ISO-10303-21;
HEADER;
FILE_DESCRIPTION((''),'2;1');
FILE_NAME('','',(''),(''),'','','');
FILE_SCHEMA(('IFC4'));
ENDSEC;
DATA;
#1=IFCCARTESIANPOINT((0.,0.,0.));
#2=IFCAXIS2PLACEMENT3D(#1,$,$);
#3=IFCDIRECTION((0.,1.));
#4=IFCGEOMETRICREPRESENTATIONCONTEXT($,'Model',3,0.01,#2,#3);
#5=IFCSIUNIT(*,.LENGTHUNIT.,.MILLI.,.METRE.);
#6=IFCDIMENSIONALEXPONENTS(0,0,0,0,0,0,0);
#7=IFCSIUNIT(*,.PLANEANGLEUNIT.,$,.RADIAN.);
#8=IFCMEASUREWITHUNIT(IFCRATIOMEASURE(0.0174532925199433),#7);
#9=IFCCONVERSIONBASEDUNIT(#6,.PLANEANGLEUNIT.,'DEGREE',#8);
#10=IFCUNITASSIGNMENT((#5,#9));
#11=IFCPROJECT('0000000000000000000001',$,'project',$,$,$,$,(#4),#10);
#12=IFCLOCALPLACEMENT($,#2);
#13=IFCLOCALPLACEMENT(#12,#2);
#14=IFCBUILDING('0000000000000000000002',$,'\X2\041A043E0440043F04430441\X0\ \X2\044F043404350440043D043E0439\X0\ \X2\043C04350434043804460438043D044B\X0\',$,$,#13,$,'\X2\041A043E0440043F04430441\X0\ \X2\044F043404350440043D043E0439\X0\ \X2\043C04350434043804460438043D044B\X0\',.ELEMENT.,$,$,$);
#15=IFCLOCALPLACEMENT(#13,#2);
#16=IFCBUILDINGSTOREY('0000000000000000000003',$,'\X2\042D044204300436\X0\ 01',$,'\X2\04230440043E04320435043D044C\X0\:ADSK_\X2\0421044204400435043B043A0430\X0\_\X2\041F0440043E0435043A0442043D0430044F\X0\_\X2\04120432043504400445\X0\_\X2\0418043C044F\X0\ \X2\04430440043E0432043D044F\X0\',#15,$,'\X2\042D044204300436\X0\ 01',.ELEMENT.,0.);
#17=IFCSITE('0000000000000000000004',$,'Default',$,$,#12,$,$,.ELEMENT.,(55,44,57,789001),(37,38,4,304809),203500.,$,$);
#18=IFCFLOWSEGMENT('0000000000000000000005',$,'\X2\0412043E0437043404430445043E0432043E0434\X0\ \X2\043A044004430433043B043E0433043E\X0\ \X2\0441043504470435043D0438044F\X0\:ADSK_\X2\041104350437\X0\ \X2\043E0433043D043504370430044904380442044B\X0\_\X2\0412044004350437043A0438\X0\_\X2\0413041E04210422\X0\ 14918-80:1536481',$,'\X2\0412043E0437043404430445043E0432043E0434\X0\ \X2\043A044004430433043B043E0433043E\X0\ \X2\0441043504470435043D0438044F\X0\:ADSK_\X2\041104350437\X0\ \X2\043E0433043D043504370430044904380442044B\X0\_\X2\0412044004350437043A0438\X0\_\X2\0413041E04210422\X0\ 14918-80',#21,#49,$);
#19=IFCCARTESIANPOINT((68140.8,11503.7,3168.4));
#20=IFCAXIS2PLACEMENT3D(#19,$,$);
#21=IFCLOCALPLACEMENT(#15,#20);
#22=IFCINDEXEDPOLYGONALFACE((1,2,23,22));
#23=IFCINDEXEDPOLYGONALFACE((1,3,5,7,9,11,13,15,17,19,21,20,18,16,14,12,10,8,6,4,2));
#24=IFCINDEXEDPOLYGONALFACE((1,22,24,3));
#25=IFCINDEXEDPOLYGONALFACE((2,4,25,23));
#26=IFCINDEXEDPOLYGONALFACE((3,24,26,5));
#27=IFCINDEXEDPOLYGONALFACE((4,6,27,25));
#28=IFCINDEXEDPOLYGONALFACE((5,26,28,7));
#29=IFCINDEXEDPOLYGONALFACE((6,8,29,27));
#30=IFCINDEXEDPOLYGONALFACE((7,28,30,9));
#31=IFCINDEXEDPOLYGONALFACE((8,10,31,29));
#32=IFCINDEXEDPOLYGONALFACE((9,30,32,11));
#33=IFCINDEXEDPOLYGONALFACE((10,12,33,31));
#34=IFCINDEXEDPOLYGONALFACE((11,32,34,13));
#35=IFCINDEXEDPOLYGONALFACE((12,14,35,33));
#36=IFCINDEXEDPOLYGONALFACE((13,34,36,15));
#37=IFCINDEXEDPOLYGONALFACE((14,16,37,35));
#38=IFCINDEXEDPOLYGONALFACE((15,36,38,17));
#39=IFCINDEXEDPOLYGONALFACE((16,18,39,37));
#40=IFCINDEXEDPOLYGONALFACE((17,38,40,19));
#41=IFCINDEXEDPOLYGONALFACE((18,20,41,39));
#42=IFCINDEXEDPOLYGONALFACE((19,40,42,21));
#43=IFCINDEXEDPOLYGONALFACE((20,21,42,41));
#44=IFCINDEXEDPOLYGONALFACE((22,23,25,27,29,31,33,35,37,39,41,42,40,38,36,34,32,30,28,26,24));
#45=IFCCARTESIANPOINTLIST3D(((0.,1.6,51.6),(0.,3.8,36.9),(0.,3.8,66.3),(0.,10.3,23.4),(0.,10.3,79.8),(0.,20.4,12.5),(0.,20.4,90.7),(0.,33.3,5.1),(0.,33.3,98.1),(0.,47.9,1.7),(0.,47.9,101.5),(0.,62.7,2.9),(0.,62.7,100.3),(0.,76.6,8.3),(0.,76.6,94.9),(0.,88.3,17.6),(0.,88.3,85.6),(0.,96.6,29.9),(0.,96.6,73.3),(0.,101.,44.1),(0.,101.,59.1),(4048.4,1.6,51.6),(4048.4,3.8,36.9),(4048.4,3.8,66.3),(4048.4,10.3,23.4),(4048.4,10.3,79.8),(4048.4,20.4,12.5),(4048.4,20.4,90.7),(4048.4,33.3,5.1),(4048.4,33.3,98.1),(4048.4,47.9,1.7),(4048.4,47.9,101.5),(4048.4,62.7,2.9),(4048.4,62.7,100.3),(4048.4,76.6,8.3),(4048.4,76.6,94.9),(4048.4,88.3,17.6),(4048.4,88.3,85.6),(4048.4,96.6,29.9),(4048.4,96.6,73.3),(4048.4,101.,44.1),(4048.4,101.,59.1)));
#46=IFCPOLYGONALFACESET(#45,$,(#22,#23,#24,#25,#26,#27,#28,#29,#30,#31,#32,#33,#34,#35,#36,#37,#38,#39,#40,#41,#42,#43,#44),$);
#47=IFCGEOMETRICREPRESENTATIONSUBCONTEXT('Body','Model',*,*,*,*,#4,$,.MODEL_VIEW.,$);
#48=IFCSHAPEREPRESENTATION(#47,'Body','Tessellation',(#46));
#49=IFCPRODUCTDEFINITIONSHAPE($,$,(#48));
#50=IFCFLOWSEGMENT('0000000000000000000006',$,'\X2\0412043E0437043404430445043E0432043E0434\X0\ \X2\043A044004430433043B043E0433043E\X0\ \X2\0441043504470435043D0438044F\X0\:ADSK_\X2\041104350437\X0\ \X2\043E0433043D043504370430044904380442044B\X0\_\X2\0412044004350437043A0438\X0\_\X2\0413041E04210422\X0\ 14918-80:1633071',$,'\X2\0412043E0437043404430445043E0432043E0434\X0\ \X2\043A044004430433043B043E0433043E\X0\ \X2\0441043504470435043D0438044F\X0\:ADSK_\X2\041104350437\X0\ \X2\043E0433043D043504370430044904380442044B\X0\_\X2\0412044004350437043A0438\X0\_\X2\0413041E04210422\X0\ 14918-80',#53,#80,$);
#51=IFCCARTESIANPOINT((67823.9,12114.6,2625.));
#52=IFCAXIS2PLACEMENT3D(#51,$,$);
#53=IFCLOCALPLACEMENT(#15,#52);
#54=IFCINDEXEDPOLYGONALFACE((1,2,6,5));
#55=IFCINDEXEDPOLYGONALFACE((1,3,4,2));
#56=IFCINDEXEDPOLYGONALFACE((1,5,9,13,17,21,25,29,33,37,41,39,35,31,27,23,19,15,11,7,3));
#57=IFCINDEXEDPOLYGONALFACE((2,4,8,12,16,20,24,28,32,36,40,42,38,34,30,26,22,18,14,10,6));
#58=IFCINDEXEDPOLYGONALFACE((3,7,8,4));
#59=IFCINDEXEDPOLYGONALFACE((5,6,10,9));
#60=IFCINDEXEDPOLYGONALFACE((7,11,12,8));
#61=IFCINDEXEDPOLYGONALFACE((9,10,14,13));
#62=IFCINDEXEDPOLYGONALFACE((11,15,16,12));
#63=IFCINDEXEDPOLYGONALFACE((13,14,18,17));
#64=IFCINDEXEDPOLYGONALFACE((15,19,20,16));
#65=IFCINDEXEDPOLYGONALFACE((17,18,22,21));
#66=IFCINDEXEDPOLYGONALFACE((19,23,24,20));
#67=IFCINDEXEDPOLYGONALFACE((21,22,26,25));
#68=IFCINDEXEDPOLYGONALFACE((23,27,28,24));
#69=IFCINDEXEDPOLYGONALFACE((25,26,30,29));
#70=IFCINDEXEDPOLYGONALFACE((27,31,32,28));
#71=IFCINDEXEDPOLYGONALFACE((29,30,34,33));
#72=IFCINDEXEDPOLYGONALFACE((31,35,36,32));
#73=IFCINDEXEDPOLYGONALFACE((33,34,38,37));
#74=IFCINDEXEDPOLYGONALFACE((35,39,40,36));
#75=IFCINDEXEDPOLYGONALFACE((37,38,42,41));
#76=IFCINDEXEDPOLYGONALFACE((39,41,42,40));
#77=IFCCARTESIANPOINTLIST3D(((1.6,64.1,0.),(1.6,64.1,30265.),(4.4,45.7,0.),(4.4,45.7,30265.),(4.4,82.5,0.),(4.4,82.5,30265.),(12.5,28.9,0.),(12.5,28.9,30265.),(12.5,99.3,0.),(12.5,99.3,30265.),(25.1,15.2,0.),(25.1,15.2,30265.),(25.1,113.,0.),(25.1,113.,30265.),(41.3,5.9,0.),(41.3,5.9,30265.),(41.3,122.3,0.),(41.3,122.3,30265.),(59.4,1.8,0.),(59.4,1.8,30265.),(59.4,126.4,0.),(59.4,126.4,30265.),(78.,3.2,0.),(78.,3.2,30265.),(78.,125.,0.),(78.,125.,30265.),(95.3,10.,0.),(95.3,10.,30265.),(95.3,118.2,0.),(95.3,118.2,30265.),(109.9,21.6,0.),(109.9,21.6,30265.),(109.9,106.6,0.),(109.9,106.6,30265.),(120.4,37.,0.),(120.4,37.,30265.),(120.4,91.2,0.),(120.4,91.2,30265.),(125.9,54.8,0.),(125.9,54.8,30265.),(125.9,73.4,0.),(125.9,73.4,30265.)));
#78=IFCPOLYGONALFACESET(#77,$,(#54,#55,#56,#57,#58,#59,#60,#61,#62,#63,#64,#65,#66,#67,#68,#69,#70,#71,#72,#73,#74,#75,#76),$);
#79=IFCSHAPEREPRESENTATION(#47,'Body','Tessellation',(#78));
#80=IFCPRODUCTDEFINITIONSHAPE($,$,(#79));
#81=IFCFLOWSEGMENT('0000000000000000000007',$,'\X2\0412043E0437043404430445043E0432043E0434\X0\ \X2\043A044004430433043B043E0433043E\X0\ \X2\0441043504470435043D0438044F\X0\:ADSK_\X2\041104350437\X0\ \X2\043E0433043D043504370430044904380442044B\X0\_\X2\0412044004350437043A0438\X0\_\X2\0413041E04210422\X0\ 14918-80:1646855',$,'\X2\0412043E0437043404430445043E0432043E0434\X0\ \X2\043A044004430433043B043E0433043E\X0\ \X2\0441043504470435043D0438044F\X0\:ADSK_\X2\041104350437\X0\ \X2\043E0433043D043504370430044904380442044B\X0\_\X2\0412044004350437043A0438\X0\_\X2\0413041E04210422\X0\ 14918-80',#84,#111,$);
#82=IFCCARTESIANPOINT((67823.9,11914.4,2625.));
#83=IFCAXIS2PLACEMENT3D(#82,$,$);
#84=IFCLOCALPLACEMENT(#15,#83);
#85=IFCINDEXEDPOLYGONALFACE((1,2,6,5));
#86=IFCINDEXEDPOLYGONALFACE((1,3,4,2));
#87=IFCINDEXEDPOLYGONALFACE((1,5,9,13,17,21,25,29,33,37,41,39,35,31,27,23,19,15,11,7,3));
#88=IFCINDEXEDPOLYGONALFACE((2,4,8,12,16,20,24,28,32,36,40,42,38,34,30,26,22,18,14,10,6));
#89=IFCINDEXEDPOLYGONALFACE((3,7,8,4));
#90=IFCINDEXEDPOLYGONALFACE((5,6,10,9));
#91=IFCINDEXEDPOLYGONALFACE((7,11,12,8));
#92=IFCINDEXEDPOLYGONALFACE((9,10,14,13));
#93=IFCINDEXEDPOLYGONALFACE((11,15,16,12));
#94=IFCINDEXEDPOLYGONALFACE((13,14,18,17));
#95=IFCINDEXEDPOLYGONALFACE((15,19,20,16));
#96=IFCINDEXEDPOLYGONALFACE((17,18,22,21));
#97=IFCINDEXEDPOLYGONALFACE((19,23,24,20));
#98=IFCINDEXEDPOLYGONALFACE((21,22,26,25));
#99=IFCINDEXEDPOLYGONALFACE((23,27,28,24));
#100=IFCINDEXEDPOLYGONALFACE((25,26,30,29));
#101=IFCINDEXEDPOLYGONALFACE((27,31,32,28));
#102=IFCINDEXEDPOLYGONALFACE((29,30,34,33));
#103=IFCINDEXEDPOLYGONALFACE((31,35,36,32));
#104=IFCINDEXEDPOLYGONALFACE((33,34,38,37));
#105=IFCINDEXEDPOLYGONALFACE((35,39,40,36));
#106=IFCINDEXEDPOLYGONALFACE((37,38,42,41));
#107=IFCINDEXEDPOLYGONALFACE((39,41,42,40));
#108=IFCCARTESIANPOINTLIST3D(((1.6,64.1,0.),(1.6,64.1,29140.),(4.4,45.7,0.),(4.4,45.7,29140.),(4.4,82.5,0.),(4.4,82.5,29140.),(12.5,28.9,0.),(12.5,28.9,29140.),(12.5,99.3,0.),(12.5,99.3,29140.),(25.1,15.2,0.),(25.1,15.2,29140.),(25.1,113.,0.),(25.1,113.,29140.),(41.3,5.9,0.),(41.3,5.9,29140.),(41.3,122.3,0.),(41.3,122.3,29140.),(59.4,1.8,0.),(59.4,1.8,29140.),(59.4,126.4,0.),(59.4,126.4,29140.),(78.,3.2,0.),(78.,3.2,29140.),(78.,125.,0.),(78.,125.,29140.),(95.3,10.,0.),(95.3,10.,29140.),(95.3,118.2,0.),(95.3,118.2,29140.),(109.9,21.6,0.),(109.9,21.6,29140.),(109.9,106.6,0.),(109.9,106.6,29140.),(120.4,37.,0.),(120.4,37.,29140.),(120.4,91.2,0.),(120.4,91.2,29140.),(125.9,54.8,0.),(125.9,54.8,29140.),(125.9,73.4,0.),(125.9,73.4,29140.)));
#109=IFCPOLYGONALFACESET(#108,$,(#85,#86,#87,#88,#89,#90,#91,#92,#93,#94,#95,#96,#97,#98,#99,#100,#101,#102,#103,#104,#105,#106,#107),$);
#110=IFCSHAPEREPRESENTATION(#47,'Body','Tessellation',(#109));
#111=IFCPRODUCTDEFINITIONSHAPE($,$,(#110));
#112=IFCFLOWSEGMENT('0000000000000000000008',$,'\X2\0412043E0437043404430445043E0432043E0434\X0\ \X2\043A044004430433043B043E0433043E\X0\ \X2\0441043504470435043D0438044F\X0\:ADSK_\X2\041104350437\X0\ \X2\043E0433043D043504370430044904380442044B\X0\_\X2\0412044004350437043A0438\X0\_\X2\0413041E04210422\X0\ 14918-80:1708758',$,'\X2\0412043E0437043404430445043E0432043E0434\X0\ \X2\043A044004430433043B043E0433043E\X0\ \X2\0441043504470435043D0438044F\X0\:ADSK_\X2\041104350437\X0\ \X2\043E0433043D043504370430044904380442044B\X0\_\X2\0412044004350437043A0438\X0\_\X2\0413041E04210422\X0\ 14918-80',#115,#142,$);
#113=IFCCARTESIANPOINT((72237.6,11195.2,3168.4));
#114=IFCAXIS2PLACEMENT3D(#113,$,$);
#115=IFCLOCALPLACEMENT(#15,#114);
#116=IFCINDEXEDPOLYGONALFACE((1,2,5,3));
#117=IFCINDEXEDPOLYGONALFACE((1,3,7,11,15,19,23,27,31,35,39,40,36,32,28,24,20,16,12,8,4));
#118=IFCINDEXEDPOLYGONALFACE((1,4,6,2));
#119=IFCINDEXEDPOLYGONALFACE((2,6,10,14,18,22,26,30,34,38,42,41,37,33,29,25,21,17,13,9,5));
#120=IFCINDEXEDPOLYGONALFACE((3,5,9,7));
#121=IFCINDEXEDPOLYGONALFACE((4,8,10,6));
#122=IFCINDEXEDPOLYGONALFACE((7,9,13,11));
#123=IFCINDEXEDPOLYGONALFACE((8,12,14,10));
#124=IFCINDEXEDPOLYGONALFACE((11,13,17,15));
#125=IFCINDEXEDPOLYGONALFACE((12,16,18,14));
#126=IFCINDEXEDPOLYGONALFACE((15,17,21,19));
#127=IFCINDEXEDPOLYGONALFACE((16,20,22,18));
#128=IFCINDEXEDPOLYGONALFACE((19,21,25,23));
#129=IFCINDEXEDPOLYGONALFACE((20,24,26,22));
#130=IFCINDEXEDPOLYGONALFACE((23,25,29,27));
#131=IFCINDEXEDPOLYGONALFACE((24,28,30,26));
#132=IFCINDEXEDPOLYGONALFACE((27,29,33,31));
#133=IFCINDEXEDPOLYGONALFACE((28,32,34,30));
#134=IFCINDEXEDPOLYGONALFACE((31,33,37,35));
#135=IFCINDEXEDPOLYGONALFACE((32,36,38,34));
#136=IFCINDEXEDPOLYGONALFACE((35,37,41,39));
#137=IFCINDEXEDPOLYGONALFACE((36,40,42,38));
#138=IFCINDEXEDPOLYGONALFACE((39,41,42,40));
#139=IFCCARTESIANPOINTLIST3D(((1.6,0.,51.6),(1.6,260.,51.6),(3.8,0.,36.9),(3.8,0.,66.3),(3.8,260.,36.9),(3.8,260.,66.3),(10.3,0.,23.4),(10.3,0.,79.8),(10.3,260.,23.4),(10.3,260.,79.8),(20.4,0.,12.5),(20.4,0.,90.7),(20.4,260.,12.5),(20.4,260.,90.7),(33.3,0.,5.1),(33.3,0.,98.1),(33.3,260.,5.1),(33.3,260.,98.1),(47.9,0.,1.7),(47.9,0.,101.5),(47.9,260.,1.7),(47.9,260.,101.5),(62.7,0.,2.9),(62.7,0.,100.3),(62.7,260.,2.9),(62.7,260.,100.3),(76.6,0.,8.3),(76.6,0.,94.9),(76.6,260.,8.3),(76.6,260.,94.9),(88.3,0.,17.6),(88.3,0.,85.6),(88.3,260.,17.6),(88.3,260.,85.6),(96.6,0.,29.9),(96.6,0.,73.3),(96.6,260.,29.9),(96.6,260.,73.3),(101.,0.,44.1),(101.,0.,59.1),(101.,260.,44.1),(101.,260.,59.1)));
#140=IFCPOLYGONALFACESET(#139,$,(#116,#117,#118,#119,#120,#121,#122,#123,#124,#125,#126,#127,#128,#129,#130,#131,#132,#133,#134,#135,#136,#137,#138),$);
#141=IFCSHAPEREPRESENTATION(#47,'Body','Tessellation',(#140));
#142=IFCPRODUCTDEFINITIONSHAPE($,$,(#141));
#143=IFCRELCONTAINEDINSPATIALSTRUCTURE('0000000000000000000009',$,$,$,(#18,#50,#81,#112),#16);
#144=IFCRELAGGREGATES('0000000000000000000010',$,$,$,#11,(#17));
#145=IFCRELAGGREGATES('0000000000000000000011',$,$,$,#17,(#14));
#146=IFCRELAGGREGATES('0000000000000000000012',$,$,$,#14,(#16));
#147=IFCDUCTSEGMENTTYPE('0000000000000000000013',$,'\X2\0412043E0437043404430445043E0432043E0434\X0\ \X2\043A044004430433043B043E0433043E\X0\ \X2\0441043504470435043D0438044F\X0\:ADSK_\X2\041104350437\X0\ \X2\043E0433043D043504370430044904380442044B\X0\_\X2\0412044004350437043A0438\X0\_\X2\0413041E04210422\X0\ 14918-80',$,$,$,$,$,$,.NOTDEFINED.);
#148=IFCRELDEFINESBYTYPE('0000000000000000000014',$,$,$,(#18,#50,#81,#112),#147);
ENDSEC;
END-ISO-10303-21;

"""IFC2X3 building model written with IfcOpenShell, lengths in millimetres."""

from ifc_helpers import new_model, entity, si_unit, converted_unit, direction, frame, origin, origin_2d_with_axis, place, context, subcontext, project, spatial, circle, extrude, type_object, element, save


model = new_model("IFC2X3")

# Units and contexts
model_context = context("Model", 3, precision=0.01, world=origin(), true_north=direction((0.0, 1.0)))
body_context = subcontext(model_context, "Body", "Model", "MODEL_VIEW")
ifc_project = project(units=[si_unit("LENGTHUNIT", "METRE", prefix="MILLI"), converted_unit("PLANEANGLEUNIT", "DEGREE", entity("IfcRatioMeasure", 0.0174532925199433), si_unit("PLANEANGLEUNIT", "RADIAN"), dimensions=[0, 0, 0, 0, 0, 0, 0])], contexts=[model_context])

# Site, building, storey
site_placement = place(None, origin())
site = spatial("IfcSite", under=ifc_project, at=site_placement, Name="Default", CompositionType="ELEMENT", RefLatitude=(55, 44, 57, 789001), RefLongitude=(37, 38, 4, 304809), RefElevation=203500.0)
building_placement = place(site_placement, origin())
building = spatial("IfcBuilding", under=site, at=building_placement, Name="Корпус ядерной медицины", LongName="Корпус ядерной медицины", CompositionType="ELEMENT")
storey_placement = place(building_placement, origin())
storey = spatial("IfcBuildingStorey", under=building, at=storey_placement, Name="Этаж 01", ObjectType="Уровень:ADSK_Стрелка_Проектная_Вверх_Имя уровня", LongName="Этаж 01", CompositionType="ELEMENT", Elevation=0.0)

# Flow segments
duct_segment_type_1 = type_object("IfcDuctSegmentType", Name="Воздуховод круглого сечения:ADSK_Без огнезащиты_Врезки_ГОСТ 14918-80", PredefinedType="NOTDEFINED")
flow_segment_1_placement = place(storey_placement, frame((68140.8, 11503.7, 3168.4)))
element("IfcFlowSegment", 1, at=flow_segment_1_placement, inside=storey, type_object=duct_segment_type_1, Name="Воздуховод круглого сечения:ADSK_Без огнезащиты_Врезки_ГОСТ 14918-80:1536481", ObjectType="Воздуховод круглого сечения:ADSK_Без огнезащиты_Врезки_ГОСТ 14918-80", context=body_context, shape_type="SweptSolid", body=[
    extrude(circle(Radius=50.0, at=origin_2d_with_axis()), frame((0.0, 51.6, 51.6), z_axis=(1.0, 0.0, 0.0), x_axis=(0.0, -1.0, 0.0)), (0.0, 0.0, 1.0), 4048.4),
])
flow_segment_2_placement = place(storey_placement, frame((67823.9, 12114.6, 2625.0)))
element("IfcFlowSegment", 2, at=flow_segment_2_placement, inside=storey, type_object=duct_segment_type_1, Name="Воздуховод круглого сечения:ADSK_Без огнезащиты_Врезки_ГОСТ 14918-80:1633071", ObjectType="Воздуховод круглого сечения:ADSK_Без огнезащиты_Врезки_ГОСТ 14918-80", context=body_context, shape_type="SweptSolid", body=[
    extrude(circle(Radius=62.5, at=origin_2d_with_axis()), frame((64.1, 64.1, 0.0), z_axis=(0.0, 0.0, 1.0), x_axis=(-1.0, 0.0, 0.0)), (0.0, 0.0, 1.0), 30265.0),
])
flow_segment_3_placement = place(storey_placement, frame((67823.9, 11914.4, 2625.0)))
element("IfcFlowSegment", 3, at=flow_segment_3_placement, inside=storey, type_object=duct_segment_type_1, Name="Воздуховод круглого сечения:ADSK_Без огнезащиты_Врезки_ГОСТ 14918-80:1646855", ObjectType="Воздуховод круглого сечения:ADSK_Без огнезащиты_Врезки_ГОСТ 14918-80", context=body_context, shape_type="SweptSolid", body=[
    extrude(circle(Radius=62.5, at=origin_2d_with_axis()), frame((64.1, 64.1, 0.0), z_axis=(0.0, 0.0, 1.0), x_axis=(-1.0, 0.0, 0.0)), (0.0, 0.0, 1.0), 29140.0),
])
flow_segment_4_placement = place(storey_placement, frame((72237.6, 11195.2, 3168.4)))
element("IfcFlowSegment", 4, at=flow_segment_4_placement, inside=storey, type_object=duct_segment_type_1, Name="Воздуховод круглого сечения:ADSK_Без огнезащиты_Врезки_ГОСТ 14918-80:1708758", ObjectType="Воздуховод круглого сечения:ADSK_Без огнезащиты_Врезки_ГОСТ 14918-80", context=body_context, shape_type="SweptSolid", body=[
    extrude(circle(Radius=50.0, at=origin_2d_with_axis()), frame((51.6, 0.0, 51.6), z_axis=(0.0, 1.0, 0.0), x_axis=(-1.0, 0.0, 0.0)), (0.0, 0.0, 1.0), 260.0),
])

save(model, "model.ifc")
